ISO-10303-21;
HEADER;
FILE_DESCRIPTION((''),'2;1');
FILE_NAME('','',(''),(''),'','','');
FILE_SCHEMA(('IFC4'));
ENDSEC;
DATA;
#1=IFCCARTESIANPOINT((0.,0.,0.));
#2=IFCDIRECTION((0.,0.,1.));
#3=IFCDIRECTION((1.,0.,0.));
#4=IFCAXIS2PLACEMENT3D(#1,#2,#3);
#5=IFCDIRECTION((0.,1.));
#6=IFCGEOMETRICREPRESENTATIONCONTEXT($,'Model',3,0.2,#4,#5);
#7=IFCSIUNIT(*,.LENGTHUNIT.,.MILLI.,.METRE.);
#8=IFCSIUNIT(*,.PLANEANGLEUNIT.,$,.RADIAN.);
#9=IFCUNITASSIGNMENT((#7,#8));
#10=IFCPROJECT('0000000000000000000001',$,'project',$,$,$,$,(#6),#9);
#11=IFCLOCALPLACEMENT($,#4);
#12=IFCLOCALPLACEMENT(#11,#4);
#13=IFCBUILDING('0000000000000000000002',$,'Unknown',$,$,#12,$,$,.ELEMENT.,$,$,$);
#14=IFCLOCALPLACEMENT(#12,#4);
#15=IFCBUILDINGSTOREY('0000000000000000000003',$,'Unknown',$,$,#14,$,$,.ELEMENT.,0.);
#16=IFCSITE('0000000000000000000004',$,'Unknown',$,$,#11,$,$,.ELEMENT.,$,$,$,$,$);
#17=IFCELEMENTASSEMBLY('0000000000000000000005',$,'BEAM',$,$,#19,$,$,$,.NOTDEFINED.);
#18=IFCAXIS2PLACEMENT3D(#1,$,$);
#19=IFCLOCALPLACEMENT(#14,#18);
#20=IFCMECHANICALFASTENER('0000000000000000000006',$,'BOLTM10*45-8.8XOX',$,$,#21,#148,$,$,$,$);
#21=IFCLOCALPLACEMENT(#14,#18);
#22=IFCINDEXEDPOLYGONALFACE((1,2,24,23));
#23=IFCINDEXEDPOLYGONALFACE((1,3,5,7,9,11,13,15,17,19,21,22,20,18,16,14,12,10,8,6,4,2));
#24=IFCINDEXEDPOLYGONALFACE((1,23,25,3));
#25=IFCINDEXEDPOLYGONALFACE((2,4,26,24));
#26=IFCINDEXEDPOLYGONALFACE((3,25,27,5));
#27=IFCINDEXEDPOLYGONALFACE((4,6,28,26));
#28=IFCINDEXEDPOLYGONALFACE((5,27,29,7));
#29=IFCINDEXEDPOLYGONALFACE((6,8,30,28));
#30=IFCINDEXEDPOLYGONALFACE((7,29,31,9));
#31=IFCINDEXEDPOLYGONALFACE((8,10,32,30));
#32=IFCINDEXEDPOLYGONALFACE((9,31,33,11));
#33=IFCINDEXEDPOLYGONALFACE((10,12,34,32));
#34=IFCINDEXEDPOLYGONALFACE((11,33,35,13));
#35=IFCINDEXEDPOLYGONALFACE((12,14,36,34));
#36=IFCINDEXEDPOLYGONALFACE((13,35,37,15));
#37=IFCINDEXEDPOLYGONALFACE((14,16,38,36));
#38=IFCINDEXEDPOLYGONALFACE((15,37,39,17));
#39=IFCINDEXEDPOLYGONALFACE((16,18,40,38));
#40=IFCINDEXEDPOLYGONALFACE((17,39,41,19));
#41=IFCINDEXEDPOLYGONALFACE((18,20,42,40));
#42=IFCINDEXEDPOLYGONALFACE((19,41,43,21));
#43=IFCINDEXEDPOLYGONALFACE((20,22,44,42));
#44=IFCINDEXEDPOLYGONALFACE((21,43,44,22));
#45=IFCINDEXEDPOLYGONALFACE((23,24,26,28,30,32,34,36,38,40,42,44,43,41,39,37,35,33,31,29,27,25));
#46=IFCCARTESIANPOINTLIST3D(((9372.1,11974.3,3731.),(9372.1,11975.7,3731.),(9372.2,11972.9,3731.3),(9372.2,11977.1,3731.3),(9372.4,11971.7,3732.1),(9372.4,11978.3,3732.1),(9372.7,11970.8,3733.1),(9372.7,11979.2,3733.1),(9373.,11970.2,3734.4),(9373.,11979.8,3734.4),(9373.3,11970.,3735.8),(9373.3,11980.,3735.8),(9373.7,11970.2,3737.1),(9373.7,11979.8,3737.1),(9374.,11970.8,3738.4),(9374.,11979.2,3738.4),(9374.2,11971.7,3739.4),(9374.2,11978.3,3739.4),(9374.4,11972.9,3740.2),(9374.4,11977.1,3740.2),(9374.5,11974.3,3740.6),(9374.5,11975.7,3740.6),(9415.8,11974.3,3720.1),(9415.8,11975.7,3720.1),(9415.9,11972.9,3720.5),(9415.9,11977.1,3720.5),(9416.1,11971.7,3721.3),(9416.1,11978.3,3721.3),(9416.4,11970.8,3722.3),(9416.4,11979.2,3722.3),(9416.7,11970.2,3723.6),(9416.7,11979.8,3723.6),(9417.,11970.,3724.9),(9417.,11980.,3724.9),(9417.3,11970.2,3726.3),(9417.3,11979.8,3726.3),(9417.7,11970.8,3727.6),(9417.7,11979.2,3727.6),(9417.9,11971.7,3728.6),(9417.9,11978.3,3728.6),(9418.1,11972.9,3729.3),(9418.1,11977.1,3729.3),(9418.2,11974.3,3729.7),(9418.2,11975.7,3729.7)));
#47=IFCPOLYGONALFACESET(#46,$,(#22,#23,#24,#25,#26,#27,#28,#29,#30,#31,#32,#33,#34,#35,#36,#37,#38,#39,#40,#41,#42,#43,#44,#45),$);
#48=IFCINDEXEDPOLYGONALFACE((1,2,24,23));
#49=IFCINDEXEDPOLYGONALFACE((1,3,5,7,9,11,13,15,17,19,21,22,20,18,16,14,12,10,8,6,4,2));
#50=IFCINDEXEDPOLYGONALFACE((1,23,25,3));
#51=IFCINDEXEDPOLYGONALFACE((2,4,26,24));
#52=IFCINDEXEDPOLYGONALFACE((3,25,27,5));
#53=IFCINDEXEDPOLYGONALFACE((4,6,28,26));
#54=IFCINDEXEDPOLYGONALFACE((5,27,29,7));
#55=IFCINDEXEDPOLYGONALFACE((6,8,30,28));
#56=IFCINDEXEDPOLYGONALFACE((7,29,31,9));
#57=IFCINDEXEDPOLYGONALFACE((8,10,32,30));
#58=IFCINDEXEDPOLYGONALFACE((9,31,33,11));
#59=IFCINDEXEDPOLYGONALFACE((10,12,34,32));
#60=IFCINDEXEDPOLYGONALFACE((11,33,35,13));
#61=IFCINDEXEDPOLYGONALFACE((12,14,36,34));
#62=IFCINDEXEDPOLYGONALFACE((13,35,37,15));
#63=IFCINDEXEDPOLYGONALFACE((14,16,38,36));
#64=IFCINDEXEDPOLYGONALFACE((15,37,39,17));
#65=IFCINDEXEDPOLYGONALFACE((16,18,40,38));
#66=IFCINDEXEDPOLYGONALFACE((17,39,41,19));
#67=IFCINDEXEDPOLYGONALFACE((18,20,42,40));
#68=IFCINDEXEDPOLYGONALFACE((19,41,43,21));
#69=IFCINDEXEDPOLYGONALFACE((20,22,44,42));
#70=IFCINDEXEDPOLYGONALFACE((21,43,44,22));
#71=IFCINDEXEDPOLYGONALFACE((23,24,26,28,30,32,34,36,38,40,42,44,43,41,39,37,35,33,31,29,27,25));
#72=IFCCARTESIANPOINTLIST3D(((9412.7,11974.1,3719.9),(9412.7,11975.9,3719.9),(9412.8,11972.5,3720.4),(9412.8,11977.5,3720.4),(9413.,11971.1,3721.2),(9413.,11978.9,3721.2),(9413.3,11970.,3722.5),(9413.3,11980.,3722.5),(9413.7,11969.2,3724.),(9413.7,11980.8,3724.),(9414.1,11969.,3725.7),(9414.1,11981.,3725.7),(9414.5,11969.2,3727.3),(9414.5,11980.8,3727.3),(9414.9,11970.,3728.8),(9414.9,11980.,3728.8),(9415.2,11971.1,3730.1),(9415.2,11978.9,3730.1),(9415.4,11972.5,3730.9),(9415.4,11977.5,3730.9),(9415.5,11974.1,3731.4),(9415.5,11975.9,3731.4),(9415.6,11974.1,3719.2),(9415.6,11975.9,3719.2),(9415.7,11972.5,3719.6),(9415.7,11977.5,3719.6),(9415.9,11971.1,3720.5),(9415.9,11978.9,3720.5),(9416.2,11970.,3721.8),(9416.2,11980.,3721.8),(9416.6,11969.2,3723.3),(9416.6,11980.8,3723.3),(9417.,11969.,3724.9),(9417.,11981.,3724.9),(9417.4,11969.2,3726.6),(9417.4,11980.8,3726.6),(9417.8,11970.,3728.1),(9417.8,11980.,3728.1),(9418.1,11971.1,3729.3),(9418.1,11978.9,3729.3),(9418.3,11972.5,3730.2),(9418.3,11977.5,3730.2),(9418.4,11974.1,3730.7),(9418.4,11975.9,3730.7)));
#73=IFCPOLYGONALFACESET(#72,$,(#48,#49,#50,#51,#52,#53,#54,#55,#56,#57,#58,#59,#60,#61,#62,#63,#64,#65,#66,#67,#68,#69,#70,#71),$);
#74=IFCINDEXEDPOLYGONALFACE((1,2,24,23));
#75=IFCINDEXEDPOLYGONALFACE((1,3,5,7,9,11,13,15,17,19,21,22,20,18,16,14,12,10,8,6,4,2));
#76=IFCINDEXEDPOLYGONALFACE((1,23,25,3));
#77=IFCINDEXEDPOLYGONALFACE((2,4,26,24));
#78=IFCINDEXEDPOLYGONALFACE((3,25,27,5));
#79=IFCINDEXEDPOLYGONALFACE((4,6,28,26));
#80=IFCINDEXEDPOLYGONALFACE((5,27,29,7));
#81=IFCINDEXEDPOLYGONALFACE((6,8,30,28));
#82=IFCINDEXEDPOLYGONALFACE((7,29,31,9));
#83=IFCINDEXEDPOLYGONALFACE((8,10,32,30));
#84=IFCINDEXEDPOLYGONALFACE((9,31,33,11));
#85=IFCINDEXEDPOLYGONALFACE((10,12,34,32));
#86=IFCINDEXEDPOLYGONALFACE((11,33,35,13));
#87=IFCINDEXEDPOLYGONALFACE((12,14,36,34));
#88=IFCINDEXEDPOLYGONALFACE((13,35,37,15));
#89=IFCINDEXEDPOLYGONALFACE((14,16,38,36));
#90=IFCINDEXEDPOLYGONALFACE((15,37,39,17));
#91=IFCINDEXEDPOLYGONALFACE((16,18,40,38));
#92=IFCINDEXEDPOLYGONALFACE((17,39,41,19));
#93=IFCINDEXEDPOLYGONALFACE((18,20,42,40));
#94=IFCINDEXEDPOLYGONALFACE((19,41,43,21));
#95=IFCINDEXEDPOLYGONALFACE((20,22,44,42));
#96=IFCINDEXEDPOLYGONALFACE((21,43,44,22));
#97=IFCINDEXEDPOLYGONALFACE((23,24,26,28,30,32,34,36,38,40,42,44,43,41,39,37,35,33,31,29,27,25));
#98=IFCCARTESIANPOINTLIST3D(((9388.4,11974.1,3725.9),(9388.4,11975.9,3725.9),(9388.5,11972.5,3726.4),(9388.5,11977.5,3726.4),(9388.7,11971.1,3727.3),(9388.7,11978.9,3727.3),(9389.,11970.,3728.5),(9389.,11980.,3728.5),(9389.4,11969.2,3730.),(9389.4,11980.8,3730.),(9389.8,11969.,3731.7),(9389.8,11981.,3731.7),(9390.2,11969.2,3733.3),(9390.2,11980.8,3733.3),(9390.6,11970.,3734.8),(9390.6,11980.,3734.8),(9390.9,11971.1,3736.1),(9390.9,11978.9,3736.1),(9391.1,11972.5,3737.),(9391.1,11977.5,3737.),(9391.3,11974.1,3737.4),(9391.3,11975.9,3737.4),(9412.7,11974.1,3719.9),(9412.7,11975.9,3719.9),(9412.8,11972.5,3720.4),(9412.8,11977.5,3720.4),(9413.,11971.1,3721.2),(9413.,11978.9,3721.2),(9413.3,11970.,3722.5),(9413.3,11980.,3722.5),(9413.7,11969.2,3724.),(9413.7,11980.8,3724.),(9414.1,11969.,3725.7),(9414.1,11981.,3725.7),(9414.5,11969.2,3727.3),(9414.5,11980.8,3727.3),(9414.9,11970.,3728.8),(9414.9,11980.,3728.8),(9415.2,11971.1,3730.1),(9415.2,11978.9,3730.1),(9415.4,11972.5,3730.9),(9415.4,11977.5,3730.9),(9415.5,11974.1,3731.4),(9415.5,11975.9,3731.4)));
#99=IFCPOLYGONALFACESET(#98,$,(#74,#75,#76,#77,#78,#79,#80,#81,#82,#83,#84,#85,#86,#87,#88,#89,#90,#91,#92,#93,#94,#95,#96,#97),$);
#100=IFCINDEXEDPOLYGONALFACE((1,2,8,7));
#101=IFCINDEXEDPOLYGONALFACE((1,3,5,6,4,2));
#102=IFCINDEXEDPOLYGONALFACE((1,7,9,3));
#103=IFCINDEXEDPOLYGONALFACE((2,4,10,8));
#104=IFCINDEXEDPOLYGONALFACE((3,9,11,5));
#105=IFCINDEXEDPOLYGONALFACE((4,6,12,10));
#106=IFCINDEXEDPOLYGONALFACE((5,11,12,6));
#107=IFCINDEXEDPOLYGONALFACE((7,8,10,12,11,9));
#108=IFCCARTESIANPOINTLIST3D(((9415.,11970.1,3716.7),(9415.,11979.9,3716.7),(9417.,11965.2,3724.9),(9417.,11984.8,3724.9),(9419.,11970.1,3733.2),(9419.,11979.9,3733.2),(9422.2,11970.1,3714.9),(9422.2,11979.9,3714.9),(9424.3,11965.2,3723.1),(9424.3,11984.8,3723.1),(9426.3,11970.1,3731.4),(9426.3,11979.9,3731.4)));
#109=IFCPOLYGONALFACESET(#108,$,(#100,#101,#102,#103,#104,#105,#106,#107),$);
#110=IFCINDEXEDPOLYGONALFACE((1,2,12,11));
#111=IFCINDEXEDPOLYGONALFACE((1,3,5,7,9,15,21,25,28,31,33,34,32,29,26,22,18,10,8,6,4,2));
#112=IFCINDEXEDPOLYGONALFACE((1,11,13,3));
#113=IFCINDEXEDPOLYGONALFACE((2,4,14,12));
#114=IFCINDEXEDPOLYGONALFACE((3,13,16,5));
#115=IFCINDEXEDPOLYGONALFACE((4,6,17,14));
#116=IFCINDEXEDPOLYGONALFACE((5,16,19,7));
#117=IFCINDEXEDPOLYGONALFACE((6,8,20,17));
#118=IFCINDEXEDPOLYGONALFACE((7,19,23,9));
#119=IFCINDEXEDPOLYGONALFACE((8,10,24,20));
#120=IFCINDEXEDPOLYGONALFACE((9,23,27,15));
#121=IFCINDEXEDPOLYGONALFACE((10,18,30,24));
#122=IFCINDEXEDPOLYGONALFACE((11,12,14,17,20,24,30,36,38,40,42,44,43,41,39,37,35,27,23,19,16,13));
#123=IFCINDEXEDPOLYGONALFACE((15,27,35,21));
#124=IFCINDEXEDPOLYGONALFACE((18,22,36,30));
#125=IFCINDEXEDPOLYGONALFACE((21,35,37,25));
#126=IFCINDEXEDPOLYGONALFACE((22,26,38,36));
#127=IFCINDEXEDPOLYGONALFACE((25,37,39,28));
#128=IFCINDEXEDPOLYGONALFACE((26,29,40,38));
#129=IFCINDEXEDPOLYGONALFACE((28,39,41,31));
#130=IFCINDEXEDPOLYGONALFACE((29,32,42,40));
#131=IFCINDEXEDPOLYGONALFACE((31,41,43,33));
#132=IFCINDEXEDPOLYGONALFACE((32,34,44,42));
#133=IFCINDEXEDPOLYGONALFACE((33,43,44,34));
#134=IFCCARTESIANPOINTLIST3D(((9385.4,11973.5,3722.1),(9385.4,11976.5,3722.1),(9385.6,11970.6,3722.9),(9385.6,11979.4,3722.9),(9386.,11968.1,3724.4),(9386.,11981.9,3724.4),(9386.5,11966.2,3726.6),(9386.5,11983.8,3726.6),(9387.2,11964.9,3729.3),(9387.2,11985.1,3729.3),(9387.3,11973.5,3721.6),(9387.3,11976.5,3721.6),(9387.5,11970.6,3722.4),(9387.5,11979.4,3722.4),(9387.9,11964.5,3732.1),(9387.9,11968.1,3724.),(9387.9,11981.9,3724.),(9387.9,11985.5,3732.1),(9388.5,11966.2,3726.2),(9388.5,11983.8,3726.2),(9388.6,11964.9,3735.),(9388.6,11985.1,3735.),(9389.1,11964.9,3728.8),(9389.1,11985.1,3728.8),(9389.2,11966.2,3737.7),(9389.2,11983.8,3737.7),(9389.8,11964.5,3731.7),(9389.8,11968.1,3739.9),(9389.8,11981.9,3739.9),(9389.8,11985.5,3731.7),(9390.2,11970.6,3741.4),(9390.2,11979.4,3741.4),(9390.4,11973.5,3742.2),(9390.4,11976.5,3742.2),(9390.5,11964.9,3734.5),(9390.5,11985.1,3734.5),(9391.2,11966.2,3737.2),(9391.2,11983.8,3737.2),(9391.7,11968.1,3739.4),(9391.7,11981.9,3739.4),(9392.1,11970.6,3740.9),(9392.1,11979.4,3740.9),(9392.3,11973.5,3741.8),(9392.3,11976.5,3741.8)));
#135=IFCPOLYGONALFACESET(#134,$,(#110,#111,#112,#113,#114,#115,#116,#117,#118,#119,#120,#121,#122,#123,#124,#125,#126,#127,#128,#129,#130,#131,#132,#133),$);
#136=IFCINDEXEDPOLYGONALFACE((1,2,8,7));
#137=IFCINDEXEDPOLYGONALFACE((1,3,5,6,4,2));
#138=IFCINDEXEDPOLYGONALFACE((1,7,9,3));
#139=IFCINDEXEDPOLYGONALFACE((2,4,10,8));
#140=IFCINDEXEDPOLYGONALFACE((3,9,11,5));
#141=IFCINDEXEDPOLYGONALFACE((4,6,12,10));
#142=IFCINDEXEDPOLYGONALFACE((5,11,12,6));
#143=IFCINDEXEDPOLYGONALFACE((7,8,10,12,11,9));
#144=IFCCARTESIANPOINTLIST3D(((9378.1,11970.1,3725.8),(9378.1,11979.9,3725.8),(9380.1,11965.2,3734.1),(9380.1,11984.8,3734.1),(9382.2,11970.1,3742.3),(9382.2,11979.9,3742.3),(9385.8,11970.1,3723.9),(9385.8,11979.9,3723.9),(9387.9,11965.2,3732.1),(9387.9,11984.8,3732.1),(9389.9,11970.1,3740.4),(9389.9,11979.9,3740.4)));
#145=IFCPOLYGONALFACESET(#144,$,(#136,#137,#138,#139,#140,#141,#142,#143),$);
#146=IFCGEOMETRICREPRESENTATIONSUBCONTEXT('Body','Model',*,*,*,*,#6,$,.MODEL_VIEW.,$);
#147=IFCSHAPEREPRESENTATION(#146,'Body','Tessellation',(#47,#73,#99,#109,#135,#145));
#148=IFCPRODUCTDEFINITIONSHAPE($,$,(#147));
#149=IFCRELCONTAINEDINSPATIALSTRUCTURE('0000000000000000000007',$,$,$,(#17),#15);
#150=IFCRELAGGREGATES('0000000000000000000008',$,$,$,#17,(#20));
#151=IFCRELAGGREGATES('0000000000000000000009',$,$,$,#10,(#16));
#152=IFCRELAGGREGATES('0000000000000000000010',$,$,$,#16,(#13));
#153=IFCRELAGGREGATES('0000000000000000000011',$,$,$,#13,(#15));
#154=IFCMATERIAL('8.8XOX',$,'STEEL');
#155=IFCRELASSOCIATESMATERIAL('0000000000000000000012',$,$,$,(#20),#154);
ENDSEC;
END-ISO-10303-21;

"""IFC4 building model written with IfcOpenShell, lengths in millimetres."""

from ifc_helpers import new_model, si_unit, direction, frame, origin_with_axes, place, context, subcontext, project, spatial, line, arc, indexed_curve, outline, extrude, source, transform, mapped, material, element, aggregate, save


model = new_model("IFC4")

# Units and contexts
model_context = context("Model", 3, precision=0.2, world=origin_with_axes(), true_north=direction((0.0, 1.0)))
body_context = subcontext(model_context, "Body", "Model", "MODEL_VIEW")
ifc_project = project(units=[si_unit("LENGTHUNIT", "METRE", prefix="MILLI"), si_unit("PLANEANGLEUNIT", "RADIAN")], contexts=[model_context])

# Site, building, storey
site_placement = place(None, origin_with_axes())
site = spatial("IfcSite", under=ifc_project, at=site_placement, Name="Unknown", CompositionType="ELEMENT")
building_placement = place(site_placement, origin_with_axes())
building = spatial("IfcBuilding", under=site, at=building_placement, Name="Unknown", CompositionType="ELEMENT")
storey_placement = place(building_placement, origin_with_axes())
storey = spatial("IfcBuildingStorey", under=building, at=storey_placement, Name="Unknown", CompositionType="ELEMENT", Elevation=0.0)

# Shared definitions
ifc_material_1 = material(Name="8.8XOX", Category="STEEL")

# Element assembly, mechanical fastener
shared_shape_1 = source(origin_with_axes(), body_context, "Body", "SweptSolid", [
    extrude(outline(indexed_curve([(5.0, 0.0), (0.0, 5.0), (-5.0, 0.0), (0.0, -5.0)], segments=[arc(1, 2, 3), arc(3, 4, 1)])), frame((0.0, 0.0, 3.8), z_axis=(0.0, 0.0, -1.0), x_axis=(0.0, 1.0, 0.0)), (0.0, 0.0, 1.0), 45.0),
    extrude(outline(indexed_curve([(6.0, 0.0), (0.0, 6.0), (-6.0, 0.0), (0.0, -6.0)], segments=[arc(1, 2, 3), arc(3, 4, 1)])), frame((0.0, 0.0, 3.8), z_axis=(0.0, 0.0, -1.0), x_axis=(0.0, 1.0, 0.0)), (0.0, 0.0, 1.0), 3.0),
    extrude(outline(indexed_curve([(6.0, 0.0), (0.0, 6.0), (-6.0, 0.0), (0.0, -6.0)], segments=[arc(1, 2, 3), arc(3, 4, 1)])), frame((0.0, 0.0, 0.8), z_axis=(0.0, 0.0, -1.0), x_axis=(0.0, 1.0, 0.0)), (0.0, 0.0, 1.0), 25.0),
    extrude(outline(indexed_curve([(9.8, 0.0), (4.9, 8.5), (-4.9, 8.5), (-9.8, 0.0), (-4.9, -8.5), (4.9, -8.5)], segments=[line(1, 2, 3, 4, 5, 6, 1)])), frame((0.0, 0.0, 11.2), z_axis=(0.0, 0.0, -1.0), x_axis=(0.0, 1.0, 0.0)), (0.0, 0.0, 1.0), 7.5),
    extrude(outline(indexed_curve([(10.5, 0.0), (0.0, 10.5), (-10.5, 0.0), (0.0, -10.5)], segments=[arc(1, 2, 3), arc(3, 4, 1)])), frame((0.0, 0.0, -24.2), z_axis=(0.0, 0.0, -1.0), x_axis=(0.0, 1.0, 0.0)), (0.0, 0.0, 1.0), 2.0),
    extrude(outline(indexed_curve([(9.8, 0.0), (4.9, 8.5), (-4.9, 8.5), (-9.8, 0.0), (-4.9, -8.5), (4.9, -8.5)], segments=[line(1, 2, 3, 4, 5, 6, 1)])), frame((0.0, 0.0, -26.2), z_axis=(0.0, 0.0, -1.0), x_axis=(0.0, 1.0, 0.0)), (0.0, 0.0, 1.0), 8.0),
])
assembly_1_placement = place(storey_placement, frame((9403.2, 6000.0, 3733.5), z_axis=(0.970613, 0.0, -0.240648), x_axis=(0.0, 1.0, 0.0)))
assembly_1 = element("IfcElementAssembly", 1, at=assembly_1_placement, inside=storey, Name="BEAM", PredefinedType="NOTDEFINED")
mechanical_fastener_1_placement = place(assembly_1_placement, frame((5975.0, -5.0, 11.8), z_axis=(0.0, 0.0, 1.0), x_axis=(0.0, 1.0, 0.0)))
mechanical_fastener_1 = element("IfcMechanicalFastener", 2, at=mechanical_fastener_1_placement, material=ifc_material_1, Name="BOLTM10*45-8.8XOX", context=body_context, shape_type="MappedRepresentation", body=[
    mapped(shared_shape_1, transform((0.0, 0.0, 0.0))),
])
aggregate(assembly_1, [mechanical_fastener_1])

save(model, "model.ifc")
